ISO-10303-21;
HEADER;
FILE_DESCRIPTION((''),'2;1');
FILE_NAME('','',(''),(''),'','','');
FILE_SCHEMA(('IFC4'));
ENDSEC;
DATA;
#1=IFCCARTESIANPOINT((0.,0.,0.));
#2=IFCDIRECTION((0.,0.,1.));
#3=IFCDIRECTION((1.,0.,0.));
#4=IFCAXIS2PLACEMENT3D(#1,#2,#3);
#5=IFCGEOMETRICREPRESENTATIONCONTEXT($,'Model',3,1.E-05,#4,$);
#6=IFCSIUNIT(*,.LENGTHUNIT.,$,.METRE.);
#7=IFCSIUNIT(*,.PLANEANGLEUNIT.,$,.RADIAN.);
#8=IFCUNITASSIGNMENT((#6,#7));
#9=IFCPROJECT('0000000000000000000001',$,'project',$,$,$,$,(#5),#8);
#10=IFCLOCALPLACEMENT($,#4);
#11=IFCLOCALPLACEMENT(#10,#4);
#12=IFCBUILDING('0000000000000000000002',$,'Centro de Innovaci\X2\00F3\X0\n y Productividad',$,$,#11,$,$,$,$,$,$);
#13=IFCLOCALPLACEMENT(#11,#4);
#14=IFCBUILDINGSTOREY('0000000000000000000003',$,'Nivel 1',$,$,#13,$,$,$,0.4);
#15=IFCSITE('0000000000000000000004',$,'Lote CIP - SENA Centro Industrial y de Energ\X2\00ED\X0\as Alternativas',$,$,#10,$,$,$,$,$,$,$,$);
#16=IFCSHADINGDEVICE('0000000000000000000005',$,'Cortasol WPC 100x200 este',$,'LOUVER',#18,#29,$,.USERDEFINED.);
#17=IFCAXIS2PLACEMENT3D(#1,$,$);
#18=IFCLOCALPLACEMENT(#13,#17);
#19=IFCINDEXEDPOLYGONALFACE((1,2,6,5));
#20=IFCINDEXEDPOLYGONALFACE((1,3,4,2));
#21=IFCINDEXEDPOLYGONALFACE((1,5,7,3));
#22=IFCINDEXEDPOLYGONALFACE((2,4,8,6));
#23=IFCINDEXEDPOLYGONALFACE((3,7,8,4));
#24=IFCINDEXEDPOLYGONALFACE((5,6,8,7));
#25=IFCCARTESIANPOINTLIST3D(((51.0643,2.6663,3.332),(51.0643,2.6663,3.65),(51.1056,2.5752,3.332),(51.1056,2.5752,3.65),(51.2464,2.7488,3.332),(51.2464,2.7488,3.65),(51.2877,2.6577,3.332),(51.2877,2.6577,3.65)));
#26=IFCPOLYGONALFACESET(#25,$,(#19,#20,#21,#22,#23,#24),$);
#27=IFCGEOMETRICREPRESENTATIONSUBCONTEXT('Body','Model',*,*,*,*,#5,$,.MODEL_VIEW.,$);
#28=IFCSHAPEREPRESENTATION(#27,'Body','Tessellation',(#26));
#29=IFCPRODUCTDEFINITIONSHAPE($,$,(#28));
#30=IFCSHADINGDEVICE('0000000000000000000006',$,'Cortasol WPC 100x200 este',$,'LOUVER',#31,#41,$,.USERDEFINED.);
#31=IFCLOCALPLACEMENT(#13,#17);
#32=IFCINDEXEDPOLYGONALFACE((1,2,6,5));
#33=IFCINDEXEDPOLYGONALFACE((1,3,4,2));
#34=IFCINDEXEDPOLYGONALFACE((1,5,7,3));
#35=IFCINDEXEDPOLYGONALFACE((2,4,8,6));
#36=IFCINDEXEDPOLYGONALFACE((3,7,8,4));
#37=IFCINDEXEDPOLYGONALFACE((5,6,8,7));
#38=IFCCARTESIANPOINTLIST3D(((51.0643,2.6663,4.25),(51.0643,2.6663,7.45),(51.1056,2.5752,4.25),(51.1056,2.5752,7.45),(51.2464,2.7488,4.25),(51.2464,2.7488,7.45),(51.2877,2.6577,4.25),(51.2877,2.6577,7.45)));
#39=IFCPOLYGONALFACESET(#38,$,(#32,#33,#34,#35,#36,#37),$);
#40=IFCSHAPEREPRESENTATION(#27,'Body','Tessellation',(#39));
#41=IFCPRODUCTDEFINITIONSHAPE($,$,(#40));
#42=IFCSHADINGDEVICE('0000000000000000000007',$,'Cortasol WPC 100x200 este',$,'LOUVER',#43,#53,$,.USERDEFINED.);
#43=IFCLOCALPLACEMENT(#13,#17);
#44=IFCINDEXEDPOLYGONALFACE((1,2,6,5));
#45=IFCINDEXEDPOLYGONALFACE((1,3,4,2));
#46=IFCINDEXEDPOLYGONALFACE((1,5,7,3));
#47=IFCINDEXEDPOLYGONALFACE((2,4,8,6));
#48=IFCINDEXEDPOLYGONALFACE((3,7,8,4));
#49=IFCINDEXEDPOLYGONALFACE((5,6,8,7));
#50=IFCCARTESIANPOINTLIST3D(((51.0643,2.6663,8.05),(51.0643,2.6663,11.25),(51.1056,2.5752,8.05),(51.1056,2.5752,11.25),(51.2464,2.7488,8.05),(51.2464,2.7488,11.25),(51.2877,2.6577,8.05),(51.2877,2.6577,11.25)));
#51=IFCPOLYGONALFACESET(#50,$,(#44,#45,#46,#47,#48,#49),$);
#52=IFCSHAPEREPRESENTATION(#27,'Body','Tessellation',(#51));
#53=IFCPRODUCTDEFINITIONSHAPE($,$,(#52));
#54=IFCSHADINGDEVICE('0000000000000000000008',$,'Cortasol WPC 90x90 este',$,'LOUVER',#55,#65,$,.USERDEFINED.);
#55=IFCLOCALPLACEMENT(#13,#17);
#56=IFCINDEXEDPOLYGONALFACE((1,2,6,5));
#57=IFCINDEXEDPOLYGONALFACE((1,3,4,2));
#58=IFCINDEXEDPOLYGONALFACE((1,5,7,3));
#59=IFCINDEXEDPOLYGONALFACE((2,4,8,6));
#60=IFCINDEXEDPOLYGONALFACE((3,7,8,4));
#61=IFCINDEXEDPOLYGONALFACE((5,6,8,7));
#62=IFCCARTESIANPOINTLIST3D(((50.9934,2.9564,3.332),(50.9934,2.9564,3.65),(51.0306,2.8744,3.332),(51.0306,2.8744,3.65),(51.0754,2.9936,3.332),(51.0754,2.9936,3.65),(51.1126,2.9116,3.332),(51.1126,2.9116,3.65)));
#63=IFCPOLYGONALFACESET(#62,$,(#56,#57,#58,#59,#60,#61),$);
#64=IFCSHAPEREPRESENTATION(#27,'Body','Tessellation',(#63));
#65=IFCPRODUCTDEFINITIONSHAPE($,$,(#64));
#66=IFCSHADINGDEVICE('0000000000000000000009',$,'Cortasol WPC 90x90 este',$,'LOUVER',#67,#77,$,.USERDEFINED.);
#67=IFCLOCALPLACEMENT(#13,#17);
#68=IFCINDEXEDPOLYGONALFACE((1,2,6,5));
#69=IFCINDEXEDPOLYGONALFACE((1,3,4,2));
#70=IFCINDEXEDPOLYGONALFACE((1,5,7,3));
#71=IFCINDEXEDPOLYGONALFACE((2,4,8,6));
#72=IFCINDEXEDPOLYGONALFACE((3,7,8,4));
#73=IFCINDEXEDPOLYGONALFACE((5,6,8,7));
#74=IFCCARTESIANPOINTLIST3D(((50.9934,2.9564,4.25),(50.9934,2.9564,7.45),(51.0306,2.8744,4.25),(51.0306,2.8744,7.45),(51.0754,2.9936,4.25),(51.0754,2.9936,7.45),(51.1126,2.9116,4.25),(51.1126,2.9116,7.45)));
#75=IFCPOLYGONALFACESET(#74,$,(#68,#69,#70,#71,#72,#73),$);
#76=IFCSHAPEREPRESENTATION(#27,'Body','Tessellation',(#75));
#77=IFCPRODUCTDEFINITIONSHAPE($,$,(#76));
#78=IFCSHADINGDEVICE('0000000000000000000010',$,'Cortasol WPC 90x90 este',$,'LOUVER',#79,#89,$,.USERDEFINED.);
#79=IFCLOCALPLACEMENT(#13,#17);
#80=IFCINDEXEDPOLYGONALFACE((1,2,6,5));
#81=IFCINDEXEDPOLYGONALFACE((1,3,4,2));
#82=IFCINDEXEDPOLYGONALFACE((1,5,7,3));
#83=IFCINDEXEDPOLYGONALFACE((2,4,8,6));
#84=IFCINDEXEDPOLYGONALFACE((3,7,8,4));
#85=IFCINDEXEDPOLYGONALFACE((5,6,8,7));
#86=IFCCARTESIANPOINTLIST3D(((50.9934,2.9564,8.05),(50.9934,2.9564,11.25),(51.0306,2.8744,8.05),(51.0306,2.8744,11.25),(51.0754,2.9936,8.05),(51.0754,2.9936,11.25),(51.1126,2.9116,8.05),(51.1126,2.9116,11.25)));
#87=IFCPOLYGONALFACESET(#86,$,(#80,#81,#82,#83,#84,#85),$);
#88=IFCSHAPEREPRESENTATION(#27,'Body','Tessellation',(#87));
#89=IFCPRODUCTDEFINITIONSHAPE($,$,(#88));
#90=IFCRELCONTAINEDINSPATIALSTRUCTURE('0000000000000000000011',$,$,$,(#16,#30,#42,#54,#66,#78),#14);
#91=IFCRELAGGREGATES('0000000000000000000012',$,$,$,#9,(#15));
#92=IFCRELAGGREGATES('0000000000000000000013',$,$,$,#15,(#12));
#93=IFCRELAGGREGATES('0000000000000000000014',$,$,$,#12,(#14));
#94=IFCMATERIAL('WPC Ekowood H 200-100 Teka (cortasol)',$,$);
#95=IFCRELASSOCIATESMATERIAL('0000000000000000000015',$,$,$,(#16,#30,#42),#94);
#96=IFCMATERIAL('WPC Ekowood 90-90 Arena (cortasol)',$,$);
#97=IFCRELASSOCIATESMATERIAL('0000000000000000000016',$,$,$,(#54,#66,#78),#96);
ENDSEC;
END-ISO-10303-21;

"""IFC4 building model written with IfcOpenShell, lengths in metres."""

from ifc_helpers import new_model, si_unit, frame, origin_with_axes, place, context, subcontext, project, spatial, polyline, outline, extrude, material, element, save


model = new_model("IFC4")

# Units and contexts
model_context = context("Model", 3, precision=1e-05, world=origin_with_axes())
body_context = subcontext(model_context, "Body", "Model", "MODEL_VIEW")
ifc_project = project(units=[si_unit("LENGTHUNIT", "METRE"), si_unit("PLANEANGLEUNIT", "RADIAN")], contexts=[model_context])

# Site, building, storey
site_placement = place(None, origin_with_axes())
site = spatial("IfcSite", under=ifc_project, at=site_placement, Name="Lote CIP - SENA Centro Industrial y de Energías Alternativas")
building_placement = place(site_placement, origin_with_axes())
building = spatial("IfcBuilding", under=site, at=building_placement, Name="Centro de Innovación y Productividad")
storey_placement = place(building_placement, origin_with_axes())
storey = spatial("IfcBuildingStorey", under=building, at=storey_placement, Name="Nivel 1", Elevation=0.4)

# Shading devices
ifc_material_1 = material(Name="WPC Ekowood 90-90 Arena (cortasol)")
ifc_material_2 = material(Name="WPC Ekowood H 200-100 Teka (cortasol)")
shading_device_1_placement = place(storey_placement, origin_with_axes())
element("IfcShadingDevice", 1, at=shading_device_1_placement, inside=storey, material=ifc_material_2, Name="Cortasol WPC 100x200 este", ObjectType="LOUVER", PredefinedType="USERDEFINED", context=body_context, shape_type="SweptSolid", body=[
    extrude(outline(polyline([(51.0643, 2.6663), (51.2464, 2.7488), (51.2877, 2.6577), (51.1056, 2.5752), (51.0643, 2.6663)])), frame((0.0, 0.0, 3.332)), (0.0, 0.0, 1.0), 0.318),
])
shading_device_2_placement = place(storey_placement, origin_with_axes())
element("IfcShadingDevice", 2, at=shading_device_2_placement, inside=storey, material=ifc_material_2, Name="Cortasol WPC 100x200 este", ObjectType="LOUVER", PredefinedType="USERDEFINED", context=body_context, shape_type="SweptSolid", body=[
    extrude(outline(polyline([(51.0643, 2.6663), (51.2464, 2.7488), (51.2877, 2.6577), (51.1056, 2.5752), (51.0643, 2.6663)])), frame((0.0, 0.0, 4.25)), (0.0, 0.0, 1.0), 3.2),
])
shading_device_3_placement = place(storey_placement, origin_with_axes())
element("IfcShadingDevice", 3, at=shading_device_3_placement, inside=storey, material=ifc_material_2, Name="Cortasol WPC 100x200 este", ObjectType="LOUVER", PredefinedType="USERDEFINED", context=body_context, shape_type="SweptSolid", body=[
    extrude(outline(polyline([(51.0643, 2.6663), (51.2464, 2.7488), (51.2877, 2.6577), (51.1056, 2.5752), (51.0643, 2.6663)])), frame((0.0, 0.0, 8.05)), (0.0, 0.0, 1.0), 3.2),
])
shading_device_4_placement = place(storey_placement, origin_with_axes())
element("IfcShadingDevice", 4, at=shading_device_4_placement, inside=storey, material=ifc_material_1, Name="Cortasol WPC 90x90 este", ObjectType="LOUVER", PredefinedType="USERDEFINED", context=body_context, shape_type="SweptSolid", body=[
    extrude(outline(polyline([(50.9934, 2.9564), (51.0754, 2.9936), (51.1126, 2.9116), (51.0306, 2.8744), (50.9934, 2.9564)])), frame((0.0, 0.0, 3.332)), (0.0, 0.0, 1.0), 0.318),
])
shading_device_5_placement = place(storey_placement, origin_with_axes())
element("IfcShadingDevice", 5, at=shading_device_5_placement, inside=storey, material=ifc_material_1, Name="Cortasol WPC 90x90 este", ObjectType="LOUVER", PredefinedType="USERDEFINED", context=body_context, shape_type="SweptSolid", body=[
    extrude(outline(polyline([(50.9934, 2.9564), (51.0754, 2.9936), (51.1126, 2.9116), (51.0306, 2.8744), (50.9934, 2.9564)])), frame((0.0, 0.0, 4.25)), (0.0, 0.0, 1.0), 3.2),
])
shading_device_6_placement = place(storey_placement, origin_with_axes())
element("IfcShadingDevice", 6, at=shading_device_6_placement, inside=storey, material=ifc_material_1, Name="Cortasol WPC 90x90 este", ObjectType="LOUVER", PredefinedType="USERDEFINED", context=body_context, shape_type="SweptSolid", body=[
    extrude(outline(polyline([(50.9934, 2.9564), (51.0754, 2.9936), (51.1126, 2.9116), (51.0306, 2.8744), (50.9934, 2.9564)])), frame((0.0, 0.0, 8.05)), (0.0, 0.0, 1.0), 3.2),
])

save(model, "model.ifc")
